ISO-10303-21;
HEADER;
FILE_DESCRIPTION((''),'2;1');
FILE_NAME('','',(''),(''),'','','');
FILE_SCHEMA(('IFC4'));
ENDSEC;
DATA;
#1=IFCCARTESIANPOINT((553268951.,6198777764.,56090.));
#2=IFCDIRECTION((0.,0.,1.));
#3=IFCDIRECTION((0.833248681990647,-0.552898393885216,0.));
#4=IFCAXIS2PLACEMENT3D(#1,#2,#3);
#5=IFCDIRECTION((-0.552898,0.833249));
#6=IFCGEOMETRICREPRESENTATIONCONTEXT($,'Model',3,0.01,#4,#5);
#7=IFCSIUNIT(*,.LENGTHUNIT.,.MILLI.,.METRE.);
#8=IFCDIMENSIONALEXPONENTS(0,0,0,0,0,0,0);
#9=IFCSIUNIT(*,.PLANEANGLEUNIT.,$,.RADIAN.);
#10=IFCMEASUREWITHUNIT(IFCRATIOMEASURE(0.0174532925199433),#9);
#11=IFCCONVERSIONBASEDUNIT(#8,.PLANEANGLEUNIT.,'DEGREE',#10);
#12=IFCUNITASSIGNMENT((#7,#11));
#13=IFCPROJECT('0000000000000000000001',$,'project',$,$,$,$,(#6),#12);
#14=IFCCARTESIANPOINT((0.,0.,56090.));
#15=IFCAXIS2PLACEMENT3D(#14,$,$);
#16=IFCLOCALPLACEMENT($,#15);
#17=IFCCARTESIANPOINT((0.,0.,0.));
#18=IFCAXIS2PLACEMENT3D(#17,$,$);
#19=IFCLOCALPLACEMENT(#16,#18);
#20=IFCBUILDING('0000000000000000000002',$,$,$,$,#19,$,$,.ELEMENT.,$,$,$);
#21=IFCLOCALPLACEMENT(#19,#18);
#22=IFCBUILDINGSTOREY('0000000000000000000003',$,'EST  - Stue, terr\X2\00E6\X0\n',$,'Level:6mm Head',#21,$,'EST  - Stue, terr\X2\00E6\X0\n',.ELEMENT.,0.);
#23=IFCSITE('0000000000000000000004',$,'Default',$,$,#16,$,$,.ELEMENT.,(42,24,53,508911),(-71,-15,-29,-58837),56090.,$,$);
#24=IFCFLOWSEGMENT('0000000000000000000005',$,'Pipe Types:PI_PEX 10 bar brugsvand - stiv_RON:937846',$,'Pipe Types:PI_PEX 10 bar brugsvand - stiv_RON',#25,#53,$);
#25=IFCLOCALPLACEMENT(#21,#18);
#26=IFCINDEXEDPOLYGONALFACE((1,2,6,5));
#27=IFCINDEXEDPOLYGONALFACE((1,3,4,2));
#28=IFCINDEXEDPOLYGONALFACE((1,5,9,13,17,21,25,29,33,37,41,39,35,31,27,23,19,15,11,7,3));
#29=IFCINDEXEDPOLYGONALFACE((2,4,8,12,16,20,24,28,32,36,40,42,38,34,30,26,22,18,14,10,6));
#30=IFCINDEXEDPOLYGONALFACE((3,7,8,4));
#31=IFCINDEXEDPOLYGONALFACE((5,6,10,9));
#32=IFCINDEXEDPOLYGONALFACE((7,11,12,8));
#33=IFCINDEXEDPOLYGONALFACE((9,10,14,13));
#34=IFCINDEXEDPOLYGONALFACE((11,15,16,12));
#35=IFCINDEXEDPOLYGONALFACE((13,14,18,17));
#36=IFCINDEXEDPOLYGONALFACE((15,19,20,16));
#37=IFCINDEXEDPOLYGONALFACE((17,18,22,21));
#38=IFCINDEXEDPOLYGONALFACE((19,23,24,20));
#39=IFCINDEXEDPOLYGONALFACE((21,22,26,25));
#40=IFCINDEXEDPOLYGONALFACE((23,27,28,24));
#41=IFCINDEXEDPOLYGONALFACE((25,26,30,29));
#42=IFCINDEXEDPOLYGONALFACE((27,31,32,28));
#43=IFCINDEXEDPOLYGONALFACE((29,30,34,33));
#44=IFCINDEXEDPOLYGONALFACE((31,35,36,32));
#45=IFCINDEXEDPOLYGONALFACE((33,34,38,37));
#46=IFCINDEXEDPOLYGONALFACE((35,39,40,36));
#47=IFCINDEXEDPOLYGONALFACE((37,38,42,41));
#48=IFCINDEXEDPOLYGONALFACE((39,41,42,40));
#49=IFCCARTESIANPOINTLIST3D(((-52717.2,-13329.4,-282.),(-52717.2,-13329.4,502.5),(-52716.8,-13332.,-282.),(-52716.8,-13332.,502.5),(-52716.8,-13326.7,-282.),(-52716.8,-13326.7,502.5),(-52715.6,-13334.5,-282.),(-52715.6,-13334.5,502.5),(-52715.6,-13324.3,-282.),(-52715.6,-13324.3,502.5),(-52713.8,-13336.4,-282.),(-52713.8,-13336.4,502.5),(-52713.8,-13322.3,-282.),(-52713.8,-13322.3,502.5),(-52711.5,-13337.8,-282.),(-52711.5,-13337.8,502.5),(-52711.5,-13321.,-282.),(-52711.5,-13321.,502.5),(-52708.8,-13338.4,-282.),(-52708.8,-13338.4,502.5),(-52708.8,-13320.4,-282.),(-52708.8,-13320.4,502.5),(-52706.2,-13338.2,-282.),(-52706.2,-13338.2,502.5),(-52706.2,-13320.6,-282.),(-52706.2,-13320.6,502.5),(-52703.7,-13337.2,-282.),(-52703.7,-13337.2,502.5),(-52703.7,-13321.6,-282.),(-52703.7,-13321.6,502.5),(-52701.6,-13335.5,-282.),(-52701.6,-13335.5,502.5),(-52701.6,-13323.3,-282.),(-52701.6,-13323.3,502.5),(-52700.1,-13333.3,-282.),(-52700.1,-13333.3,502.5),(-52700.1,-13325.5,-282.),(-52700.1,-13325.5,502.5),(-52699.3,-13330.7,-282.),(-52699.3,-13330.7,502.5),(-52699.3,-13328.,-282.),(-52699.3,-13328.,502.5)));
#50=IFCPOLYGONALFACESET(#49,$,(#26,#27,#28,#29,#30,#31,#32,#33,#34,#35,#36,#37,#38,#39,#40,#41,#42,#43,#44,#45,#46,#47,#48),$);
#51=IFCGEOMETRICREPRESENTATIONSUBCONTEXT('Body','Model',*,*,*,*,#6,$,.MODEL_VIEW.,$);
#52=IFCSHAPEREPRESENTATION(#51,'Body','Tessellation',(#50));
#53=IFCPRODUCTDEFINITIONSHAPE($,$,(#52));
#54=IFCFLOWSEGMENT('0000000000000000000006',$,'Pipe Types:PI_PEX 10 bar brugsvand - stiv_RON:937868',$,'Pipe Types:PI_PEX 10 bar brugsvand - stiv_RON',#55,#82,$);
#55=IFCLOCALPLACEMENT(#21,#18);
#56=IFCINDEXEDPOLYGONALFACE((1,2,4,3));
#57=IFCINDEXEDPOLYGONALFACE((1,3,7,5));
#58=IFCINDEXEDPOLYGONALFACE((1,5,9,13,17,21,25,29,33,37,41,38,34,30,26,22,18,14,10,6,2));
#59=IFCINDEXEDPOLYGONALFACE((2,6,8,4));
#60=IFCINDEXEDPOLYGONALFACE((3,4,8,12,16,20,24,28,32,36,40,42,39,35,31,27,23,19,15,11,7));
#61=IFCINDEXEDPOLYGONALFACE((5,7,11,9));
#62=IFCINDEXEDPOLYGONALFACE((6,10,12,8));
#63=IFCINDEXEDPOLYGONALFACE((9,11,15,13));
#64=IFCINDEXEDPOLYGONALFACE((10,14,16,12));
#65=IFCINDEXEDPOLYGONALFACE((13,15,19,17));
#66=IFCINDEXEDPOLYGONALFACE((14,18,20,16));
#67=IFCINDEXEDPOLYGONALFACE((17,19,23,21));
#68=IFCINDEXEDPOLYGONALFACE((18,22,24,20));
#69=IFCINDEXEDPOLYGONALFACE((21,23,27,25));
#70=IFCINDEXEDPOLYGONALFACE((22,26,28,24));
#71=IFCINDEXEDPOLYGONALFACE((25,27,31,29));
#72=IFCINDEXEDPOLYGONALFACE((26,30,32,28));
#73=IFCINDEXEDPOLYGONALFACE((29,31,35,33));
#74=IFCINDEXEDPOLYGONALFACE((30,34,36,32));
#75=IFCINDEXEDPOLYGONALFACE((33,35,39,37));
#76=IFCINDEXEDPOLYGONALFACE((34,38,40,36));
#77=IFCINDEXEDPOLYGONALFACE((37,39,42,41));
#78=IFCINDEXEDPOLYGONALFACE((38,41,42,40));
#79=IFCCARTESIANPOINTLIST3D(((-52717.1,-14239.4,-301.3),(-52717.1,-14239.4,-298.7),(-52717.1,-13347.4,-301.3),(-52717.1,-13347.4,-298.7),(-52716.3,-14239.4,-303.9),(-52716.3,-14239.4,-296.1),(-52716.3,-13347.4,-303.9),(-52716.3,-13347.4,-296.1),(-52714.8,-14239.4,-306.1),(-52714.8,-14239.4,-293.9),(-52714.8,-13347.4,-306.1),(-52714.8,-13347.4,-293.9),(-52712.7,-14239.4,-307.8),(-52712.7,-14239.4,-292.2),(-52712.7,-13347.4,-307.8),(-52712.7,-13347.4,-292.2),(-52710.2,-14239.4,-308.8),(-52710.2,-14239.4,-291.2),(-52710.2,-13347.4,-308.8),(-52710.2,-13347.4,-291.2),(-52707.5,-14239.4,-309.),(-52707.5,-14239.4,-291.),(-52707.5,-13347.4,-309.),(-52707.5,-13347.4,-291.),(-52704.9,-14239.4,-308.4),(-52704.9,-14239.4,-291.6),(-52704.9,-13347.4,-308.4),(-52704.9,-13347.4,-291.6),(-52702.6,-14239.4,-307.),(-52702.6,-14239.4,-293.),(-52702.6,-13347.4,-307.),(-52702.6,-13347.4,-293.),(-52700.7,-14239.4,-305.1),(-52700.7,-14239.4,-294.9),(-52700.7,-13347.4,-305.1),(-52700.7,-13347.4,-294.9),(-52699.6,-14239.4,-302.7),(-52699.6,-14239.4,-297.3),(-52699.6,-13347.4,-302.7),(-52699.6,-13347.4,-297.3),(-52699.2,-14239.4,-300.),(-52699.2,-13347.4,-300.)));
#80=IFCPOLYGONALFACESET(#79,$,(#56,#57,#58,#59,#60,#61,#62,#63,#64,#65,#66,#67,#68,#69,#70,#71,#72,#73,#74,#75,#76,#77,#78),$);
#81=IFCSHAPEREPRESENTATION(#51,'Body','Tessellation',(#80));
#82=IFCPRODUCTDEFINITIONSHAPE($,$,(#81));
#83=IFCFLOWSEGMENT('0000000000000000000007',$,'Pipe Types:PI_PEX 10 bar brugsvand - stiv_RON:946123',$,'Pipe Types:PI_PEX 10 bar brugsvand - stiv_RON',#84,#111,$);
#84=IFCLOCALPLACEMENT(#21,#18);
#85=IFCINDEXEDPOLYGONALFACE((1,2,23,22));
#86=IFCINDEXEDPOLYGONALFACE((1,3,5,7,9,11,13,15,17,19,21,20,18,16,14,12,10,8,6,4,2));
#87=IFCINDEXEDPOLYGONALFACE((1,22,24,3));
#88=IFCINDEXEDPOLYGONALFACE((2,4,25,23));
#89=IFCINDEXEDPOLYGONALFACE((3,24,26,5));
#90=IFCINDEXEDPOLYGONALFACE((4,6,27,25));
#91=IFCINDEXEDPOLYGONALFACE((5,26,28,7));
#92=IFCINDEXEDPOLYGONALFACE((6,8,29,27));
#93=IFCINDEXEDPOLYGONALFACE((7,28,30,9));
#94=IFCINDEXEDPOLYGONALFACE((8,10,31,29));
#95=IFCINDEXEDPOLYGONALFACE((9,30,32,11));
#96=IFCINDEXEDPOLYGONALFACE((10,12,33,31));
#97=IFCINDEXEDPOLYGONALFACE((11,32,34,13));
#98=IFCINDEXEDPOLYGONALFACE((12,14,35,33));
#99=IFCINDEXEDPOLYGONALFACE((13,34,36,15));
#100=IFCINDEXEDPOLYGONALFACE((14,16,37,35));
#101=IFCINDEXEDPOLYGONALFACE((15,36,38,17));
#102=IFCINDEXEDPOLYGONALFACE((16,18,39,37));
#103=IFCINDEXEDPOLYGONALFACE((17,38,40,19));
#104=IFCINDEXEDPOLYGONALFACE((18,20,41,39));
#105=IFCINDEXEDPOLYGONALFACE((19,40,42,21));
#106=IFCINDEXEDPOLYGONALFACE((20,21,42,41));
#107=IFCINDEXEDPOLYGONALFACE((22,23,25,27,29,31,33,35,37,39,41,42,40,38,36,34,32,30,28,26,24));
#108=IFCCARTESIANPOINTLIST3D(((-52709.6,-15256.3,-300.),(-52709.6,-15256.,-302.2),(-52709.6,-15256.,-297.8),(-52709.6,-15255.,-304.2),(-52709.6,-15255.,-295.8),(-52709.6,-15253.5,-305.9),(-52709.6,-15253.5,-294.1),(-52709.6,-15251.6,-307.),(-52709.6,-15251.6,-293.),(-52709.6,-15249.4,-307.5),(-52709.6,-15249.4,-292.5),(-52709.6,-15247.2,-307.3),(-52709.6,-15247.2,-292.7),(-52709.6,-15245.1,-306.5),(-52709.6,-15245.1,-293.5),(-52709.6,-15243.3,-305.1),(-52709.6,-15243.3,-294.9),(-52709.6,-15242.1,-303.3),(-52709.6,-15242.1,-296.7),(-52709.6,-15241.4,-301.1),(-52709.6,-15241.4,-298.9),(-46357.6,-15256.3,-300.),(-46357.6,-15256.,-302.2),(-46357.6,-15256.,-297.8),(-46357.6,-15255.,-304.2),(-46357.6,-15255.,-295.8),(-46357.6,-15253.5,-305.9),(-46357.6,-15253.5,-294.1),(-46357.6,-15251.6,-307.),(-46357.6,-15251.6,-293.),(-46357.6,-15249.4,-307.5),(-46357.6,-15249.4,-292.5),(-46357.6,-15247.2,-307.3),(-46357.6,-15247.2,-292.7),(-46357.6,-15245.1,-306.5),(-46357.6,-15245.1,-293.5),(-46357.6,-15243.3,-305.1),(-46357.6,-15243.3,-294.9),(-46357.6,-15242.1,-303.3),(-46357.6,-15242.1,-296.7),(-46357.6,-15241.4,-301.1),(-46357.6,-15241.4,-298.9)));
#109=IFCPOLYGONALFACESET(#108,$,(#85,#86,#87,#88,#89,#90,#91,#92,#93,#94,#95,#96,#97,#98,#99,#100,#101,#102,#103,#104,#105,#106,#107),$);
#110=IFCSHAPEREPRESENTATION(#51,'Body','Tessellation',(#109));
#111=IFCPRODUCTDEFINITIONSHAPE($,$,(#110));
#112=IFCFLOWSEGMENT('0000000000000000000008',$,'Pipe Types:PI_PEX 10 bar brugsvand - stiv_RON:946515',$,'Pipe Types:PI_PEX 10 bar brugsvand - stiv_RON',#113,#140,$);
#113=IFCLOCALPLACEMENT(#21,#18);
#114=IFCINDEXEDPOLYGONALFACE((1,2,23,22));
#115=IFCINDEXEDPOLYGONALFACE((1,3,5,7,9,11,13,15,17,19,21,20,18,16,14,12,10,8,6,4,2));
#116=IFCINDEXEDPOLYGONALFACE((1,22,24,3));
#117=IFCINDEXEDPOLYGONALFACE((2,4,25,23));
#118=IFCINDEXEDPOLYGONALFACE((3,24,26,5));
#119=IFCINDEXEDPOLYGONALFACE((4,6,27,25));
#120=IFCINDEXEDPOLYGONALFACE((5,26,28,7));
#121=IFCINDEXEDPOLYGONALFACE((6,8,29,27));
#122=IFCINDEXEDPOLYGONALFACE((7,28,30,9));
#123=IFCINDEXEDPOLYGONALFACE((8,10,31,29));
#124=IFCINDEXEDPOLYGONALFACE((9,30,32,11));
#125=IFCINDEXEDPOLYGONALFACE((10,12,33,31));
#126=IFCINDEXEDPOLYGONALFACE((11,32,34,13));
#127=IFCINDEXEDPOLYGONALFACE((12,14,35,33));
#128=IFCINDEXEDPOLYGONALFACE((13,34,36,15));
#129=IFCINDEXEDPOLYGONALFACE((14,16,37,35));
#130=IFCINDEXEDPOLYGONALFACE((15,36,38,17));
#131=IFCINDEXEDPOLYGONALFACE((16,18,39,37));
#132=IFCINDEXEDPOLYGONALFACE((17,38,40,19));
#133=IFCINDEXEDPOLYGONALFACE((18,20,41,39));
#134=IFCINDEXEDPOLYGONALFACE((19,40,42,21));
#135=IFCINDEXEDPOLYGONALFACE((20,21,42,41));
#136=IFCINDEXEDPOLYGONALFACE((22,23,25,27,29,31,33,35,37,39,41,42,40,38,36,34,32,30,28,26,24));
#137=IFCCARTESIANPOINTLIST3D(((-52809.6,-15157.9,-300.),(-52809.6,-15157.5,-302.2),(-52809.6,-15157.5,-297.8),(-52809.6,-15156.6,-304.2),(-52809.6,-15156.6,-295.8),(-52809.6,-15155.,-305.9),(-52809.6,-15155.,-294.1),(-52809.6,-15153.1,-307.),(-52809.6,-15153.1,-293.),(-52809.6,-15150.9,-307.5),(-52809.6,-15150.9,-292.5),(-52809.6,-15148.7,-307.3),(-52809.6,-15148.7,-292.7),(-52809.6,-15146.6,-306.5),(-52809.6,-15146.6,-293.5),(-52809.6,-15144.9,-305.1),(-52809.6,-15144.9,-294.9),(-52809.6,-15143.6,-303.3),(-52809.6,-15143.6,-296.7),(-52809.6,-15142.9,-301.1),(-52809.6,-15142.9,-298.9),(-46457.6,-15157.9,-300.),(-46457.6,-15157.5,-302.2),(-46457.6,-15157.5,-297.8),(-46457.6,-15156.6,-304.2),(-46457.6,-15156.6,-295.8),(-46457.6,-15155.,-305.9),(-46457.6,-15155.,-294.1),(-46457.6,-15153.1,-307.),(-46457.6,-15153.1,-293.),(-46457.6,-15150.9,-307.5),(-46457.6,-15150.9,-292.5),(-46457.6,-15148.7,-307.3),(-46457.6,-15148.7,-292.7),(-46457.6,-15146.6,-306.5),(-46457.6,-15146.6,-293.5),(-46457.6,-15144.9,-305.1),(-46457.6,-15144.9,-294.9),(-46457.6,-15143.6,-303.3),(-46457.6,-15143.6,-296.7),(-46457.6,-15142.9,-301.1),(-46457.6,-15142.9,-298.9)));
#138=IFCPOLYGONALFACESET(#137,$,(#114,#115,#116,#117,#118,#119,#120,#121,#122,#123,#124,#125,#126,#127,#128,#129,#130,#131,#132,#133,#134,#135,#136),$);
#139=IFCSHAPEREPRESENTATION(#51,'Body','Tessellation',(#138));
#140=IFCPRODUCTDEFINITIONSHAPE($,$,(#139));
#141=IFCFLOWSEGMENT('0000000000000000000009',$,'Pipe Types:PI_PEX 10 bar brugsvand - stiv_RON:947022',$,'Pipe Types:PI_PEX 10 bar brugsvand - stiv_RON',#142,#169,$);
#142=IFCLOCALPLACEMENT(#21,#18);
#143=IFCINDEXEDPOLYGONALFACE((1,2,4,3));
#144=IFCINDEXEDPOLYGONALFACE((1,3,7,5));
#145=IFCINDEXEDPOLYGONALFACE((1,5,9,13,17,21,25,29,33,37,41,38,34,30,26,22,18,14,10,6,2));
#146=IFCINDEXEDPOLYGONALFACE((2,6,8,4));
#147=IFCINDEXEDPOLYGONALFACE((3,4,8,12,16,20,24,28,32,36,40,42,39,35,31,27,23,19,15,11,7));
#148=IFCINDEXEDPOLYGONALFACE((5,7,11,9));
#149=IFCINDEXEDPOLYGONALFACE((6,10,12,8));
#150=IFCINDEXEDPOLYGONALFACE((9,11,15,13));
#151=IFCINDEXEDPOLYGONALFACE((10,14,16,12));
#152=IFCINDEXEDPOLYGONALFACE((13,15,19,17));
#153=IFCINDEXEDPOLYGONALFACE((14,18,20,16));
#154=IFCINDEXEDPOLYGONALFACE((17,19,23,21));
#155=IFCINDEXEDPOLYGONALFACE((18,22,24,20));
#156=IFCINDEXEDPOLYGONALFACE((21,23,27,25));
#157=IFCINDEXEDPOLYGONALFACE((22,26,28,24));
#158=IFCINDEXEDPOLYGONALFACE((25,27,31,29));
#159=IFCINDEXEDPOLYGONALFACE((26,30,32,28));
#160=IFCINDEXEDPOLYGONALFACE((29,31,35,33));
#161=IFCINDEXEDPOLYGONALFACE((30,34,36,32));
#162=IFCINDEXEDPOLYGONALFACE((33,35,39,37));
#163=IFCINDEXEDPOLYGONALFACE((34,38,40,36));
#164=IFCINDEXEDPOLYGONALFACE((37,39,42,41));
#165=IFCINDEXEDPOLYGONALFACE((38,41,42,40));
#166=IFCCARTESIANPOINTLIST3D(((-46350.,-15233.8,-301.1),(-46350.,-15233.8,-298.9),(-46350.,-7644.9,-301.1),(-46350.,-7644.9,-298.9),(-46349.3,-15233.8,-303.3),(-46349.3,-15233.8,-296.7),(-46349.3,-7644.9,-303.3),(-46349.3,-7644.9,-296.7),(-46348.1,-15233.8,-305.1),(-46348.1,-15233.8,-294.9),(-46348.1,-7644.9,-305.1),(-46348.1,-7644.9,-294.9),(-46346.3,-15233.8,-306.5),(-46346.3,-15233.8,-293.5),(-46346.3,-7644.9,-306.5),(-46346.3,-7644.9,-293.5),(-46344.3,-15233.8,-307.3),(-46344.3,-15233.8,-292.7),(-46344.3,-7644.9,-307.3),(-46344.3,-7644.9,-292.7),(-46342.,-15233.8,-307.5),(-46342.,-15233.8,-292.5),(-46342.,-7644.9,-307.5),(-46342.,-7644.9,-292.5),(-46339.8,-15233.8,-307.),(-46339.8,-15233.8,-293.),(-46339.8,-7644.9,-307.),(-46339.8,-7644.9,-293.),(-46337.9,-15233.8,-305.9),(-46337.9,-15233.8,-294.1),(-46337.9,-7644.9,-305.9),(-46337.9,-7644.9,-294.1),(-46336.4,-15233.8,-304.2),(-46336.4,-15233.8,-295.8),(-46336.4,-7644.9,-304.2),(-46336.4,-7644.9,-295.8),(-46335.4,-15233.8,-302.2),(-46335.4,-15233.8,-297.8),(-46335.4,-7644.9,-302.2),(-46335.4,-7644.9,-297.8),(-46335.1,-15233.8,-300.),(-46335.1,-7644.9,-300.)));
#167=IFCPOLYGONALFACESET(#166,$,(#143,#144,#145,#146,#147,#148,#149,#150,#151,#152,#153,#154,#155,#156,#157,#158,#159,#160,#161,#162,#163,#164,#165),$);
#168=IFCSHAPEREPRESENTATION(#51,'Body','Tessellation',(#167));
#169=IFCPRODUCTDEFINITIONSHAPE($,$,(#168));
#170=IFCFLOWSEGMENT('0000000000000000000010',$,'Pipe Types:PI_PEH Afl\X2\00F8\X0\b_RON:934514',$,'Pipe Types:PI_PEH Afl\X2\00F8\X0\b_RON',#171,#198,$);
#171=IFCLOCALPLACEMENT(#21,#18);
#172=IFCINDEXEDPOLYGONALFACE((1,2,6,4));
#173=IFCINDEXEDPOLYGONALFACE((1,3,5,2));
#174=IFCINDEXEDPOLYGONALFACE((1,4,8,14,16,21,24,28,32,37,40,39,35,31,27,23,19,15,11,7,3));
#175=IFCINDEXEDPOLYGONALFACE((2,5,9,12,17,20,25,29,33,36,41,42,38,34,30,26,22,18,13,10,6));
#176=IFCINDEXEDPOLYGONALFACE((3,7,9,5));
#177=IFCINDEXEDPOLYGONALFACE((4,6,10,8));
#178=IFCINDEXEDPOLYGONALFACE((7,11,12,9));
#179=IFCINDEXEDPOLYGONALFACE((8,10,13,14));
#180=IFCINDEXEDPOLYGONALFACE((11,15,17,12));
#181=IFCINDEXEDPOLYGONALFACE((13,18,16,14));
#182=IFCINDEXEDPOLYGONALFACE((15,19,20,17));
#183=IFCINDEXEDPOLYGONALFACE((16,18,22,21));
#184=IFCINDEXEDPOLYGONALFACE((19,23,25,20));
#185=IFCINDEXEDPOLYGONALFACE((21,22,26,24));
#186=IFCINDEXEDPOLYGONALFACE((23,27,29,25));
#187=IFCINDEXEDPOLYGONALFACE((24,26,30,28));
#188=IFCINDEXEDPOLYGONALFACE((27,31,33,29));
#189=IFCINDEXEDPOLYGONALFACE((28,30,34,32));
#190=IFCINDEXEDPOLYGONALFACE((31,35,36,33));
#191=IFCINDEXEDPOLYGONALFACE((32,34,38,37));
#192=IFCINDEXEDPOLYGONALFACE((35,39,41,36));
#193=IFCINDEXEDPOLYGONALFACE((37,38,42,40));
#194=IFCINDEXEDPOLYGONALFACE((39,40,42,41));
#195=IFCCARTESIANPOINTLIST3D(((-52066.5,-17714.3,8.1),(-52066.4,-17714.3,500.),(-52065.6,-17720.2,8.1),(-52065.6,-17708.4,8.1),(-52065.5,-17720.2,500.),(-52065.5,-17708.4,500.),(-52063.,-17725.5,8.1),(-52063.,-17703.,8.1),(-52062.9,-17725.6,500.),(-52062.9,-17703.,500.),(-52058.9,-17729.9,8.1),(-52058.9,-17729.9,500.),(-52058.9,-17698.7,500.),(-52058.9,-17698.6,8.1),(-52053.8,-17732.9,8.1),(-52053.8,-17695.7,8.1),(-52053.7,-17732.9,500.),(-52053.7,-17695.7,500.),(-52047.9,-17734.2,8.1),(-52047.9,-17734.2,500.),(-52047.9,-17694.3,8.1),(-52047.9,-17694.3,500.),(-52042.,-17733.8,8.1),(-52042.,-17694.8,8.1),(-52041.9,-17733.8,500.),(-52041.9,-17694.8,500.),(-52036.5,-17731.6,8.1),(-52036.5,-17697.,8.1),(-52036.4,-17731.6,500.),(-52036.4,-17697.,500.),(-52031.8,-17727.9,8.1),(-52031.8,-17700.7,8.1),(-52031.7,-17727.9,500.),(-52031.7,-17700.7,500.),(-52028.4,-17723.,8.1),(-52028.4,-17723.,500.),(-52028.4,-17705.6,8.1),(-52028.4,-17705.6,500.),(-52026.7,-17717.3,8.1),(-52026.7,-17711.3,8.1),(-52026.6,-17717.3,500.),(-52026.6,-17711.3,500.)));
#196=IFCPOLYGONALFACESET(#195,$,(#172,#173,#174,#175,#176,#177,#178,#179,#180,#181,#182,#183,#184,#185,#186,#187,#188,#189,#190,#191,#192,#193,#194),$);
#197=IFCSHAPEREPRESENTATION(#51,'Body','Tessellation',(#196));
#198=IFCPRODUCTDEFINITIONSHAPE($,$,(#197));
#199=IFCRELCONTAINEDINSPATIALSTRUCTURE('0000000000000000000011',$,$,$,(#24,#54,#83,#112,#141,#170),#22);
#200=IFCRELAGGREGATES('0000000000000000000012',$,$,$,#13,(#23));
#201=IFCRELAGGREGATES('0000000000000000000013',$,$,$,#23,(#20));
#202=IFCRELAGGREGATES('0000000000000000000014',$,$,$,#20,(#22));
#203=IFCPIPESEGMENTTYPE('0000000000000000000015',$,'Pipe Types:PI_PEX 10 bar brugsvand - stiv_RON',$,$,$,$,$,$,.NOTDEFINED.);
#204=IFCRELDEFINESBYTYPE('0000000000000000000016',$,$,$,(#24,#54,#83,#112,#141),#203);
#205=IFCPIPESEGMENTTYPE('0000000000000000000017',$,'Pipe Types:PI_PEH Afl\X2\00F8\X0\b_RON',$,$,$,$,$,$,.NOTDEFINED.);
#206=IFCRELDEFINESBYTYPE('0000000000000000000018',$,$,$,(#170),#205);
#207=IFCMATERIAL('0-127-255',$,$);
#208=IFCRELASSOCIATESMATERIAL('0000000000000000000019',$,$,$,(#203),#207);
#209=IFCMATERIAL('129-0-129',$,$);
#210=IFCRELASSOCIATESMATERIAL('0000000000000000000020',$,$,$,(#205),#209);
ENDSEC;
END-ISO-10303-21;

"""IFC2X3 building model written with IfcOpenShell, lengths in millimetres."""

from ifc_helpers import new_model, entity, si_unit, converted_unit, direction, frame, origin, origin_2d_with_axis, place, context, subcontext, project, spatial, circle, extrude, material, type_object, element, save


model = new_model("IFC2X3")

# Units and contexts
model_context = context("Model", 3, precision=0.01, world=frame((553268951.0, 6198777764.0, 56090.0), z_axis=(0.0, 0.0, 1.0), x_axis=(0.833248681990647, -0.552898393885216, 0.0)), true_north=direction((-0.552898, 0.833249)))
body_context = subcontext(model_context, "Body", "Model", "MODEL_VIEW")
ifc_project = project(units=[si_unit("LENGTHUNIT", "METRE", prefix="MILLI"), converted_unit("PLANEANGLEUNIT", "DEGREE", entity("IfcRatioMeasure", 0.0174532925199433), si_unit("PLANEANGLEUNIT", "RADIAN"), dimensions=[0, 0, 0, 0, 0, 0, 0])], contexts=[model_context])

# Site, building, storey
site_placement = place(None, frame((0.0, 0.0, 56090.0)))
site = spatial("IfcSite", under=ifc_project, at=site_placement, Name="Default", CompositionType="ELEMENT", RefLatitude=(42, 24, 53, 508911), RefLongitude=(-71, -15, -29, -58837), RefElevation=56090.0)
building_placement = place(site_placement, origin())
building = spatial("IfcBuilding", under=site, at=building_placement, CompositionType="ELEMENT")
storey_placement = place(building_placement, frame((0.0, 0.0, 0.0)))
storey = spatial("IfcBuildingStorey", under=building, at=storey_placement, Name="EST  - Stue, terræn", ObjectType="Level:6mm Head", LongName="EST  - Stue, terræn", CompositionType="ELEMENT", Elevation=0.0)

# Flow segments
ifc_material_1 = material(Name="0-127-255")
pipe_segment_type_1 = type_object("IfcPipeSegmentType", Name="Pipe Types:PI_PEX 10 bar brugsvand - stiv_RON", PredefinedType="NOTDEFINED", material=ifc_material_1)
flow_segment_1_placement = place(storey_placement, origin())
element("IfcFlowSegment", 1, at=flow_segment_1_placement, inside=storey, type_object=pipe_segment_type_1, Name="Pipe Types:PI_PEX 10 bar brugsvand - stiv_RON:937846", ObjectType="Pipe Types:PI_PEX 10 bar brugsvand - stiv_RON", context=body_context, shape_type="SweptSolid", body=[
    extrude(circle(Radius=9.0, at=origin_2d_with_axis()), frame((-52708.2, -13329.4, -282.0), z_axis=(0.0, 0.0, 1.0), x_axis=(-1.0, 0.0, 0.0)), (0.0, 0.0, 1.0), 784.5),
])
flow_segment_2_placement = place(storey_placement, origin())
element("IfcFlowSegment", 2, at=flow_segment_2_placement, inside=storey, type_object=pipe_segment_type_1, Name="Pipe Types:PI_PEX 10 bar brugsvand - stiv_RON:937868", ObjectType="Pipe Types:PI_PEX 10 bar brugsvand - stiv_RON", context=body_context, shape_type="SweptSolid", body=[
    extrude(circle(Radius=9.0, at=origin_2d_with_axis()), frame((-52708.2, -14239.4, -300.0), z_axis=(0.0, 1.0, 0.0), x_axis=(1.0, 0.0, 0.0)), (0.0, 0.0, 1.0), 892.0),
])
flow_segment_3_placement = place(storey_placement, origin())
element("IfcFlowSegment", 3, at=flow_segment_3_placement, inside=storey, type_object=pipe_segment_type_1, Name="Pipe Types:PI_PEX 10 bar brugsvand - stiv_RON:946123", ObjectType="Pipe Types:PI_PEX 10 bar brugsvand - stiv_RON", context=body_context, shape_type="SweptSolid", body=[
    extrude(circle(Radius=7.5, at=origin_2d_with_axis()), frame((-52709.6, -15248.8, -300.0), z_axis=(1.0, 0.0, 0.0), x_axis=(0.0, -1.0, 0.0)), (0.0, 0.0, 1.0), 6352.0),
])
flow_segment_4_placement = place(storey_placement, origin())
element("IfcFlowSegment", 4, at=flow_segment_4_placement, inside=storey, type_object=pipe_segment_type_1, Name="Pipe Types:PI_PEX 10 bar brugsvand - stiv_RON:946515", ObjectType="Pipe Types:PI_PEX 10 bar brugsvand - stiv_RON", context=body_context, shape_type="SweptSolid", body=[
    extrude(circle(Radius=7.5, at=origin_2d_with_axis()), frame((-52809.6, -15150.4, -300.0), z_axis=(1.0, 0.0, 0.0), x_axis=(0.0, -1.0, 0.0)), (0.0, 0.0, 1.0), 6352.0),
])
flow_segment_5_placement = place(storey_placement, origin())
element("IfcFlowSegment", 5, at=flow_segment_5_placement, inside=storey, type_object=pipe_segment_type_1, Name="Pipe Types:PI_PEX 10 bar brugsvand - stiv_RON:947022", ObjectType="Pipe Types:PI_PEX 10 bar brugsvand - stiv_RON", context=body_context, shape_type="SweptSolid", body=[
    extrude(circle(Radius=7.5, at=origin_2d_with_axis()), frame((-46342.6, -15233.8, -300.0), z_axis=(0.0, 1.0, 0.0), x_axis=(1.0, 0.0, 0.0)), (0.0, 0.0, 1.0), 7589.0),
])
ifc_material_2 = material(Name="129-0-129")
pipe_segment_type_2 = type_object("IfcPipeSegmentType", Name="Pipe Types:PI_PEH Afløb_RON", PredefinedType="NOTDEFINED", material=ifc_material_2)
flow_segment_6_placement = place(storey_placement, origin())
element("IfcFlowSegment", 6, at=flow_segment_6_placement, inside=storey, type_object=pipe_segment_type_2, Name="Pipe Types:PI_PEH Afløb_RON:934514", ObjectType="Pipe Types:PI_PEH Afløb_RON", context=body_context, shape_type="SweptSolid", body=[
    extrude(circle(Radius=20.0, at=origin_2d_with_axis()), frame((-52046.5, -17714.3, 8.1), z_axis=(0.000126, -0.000015, 1.0), x_axis=(-1.0, 0.0, 0.000126)), (0.0, 0.0, 1.0), 491.9),
])

save(model, "model.ifc")
